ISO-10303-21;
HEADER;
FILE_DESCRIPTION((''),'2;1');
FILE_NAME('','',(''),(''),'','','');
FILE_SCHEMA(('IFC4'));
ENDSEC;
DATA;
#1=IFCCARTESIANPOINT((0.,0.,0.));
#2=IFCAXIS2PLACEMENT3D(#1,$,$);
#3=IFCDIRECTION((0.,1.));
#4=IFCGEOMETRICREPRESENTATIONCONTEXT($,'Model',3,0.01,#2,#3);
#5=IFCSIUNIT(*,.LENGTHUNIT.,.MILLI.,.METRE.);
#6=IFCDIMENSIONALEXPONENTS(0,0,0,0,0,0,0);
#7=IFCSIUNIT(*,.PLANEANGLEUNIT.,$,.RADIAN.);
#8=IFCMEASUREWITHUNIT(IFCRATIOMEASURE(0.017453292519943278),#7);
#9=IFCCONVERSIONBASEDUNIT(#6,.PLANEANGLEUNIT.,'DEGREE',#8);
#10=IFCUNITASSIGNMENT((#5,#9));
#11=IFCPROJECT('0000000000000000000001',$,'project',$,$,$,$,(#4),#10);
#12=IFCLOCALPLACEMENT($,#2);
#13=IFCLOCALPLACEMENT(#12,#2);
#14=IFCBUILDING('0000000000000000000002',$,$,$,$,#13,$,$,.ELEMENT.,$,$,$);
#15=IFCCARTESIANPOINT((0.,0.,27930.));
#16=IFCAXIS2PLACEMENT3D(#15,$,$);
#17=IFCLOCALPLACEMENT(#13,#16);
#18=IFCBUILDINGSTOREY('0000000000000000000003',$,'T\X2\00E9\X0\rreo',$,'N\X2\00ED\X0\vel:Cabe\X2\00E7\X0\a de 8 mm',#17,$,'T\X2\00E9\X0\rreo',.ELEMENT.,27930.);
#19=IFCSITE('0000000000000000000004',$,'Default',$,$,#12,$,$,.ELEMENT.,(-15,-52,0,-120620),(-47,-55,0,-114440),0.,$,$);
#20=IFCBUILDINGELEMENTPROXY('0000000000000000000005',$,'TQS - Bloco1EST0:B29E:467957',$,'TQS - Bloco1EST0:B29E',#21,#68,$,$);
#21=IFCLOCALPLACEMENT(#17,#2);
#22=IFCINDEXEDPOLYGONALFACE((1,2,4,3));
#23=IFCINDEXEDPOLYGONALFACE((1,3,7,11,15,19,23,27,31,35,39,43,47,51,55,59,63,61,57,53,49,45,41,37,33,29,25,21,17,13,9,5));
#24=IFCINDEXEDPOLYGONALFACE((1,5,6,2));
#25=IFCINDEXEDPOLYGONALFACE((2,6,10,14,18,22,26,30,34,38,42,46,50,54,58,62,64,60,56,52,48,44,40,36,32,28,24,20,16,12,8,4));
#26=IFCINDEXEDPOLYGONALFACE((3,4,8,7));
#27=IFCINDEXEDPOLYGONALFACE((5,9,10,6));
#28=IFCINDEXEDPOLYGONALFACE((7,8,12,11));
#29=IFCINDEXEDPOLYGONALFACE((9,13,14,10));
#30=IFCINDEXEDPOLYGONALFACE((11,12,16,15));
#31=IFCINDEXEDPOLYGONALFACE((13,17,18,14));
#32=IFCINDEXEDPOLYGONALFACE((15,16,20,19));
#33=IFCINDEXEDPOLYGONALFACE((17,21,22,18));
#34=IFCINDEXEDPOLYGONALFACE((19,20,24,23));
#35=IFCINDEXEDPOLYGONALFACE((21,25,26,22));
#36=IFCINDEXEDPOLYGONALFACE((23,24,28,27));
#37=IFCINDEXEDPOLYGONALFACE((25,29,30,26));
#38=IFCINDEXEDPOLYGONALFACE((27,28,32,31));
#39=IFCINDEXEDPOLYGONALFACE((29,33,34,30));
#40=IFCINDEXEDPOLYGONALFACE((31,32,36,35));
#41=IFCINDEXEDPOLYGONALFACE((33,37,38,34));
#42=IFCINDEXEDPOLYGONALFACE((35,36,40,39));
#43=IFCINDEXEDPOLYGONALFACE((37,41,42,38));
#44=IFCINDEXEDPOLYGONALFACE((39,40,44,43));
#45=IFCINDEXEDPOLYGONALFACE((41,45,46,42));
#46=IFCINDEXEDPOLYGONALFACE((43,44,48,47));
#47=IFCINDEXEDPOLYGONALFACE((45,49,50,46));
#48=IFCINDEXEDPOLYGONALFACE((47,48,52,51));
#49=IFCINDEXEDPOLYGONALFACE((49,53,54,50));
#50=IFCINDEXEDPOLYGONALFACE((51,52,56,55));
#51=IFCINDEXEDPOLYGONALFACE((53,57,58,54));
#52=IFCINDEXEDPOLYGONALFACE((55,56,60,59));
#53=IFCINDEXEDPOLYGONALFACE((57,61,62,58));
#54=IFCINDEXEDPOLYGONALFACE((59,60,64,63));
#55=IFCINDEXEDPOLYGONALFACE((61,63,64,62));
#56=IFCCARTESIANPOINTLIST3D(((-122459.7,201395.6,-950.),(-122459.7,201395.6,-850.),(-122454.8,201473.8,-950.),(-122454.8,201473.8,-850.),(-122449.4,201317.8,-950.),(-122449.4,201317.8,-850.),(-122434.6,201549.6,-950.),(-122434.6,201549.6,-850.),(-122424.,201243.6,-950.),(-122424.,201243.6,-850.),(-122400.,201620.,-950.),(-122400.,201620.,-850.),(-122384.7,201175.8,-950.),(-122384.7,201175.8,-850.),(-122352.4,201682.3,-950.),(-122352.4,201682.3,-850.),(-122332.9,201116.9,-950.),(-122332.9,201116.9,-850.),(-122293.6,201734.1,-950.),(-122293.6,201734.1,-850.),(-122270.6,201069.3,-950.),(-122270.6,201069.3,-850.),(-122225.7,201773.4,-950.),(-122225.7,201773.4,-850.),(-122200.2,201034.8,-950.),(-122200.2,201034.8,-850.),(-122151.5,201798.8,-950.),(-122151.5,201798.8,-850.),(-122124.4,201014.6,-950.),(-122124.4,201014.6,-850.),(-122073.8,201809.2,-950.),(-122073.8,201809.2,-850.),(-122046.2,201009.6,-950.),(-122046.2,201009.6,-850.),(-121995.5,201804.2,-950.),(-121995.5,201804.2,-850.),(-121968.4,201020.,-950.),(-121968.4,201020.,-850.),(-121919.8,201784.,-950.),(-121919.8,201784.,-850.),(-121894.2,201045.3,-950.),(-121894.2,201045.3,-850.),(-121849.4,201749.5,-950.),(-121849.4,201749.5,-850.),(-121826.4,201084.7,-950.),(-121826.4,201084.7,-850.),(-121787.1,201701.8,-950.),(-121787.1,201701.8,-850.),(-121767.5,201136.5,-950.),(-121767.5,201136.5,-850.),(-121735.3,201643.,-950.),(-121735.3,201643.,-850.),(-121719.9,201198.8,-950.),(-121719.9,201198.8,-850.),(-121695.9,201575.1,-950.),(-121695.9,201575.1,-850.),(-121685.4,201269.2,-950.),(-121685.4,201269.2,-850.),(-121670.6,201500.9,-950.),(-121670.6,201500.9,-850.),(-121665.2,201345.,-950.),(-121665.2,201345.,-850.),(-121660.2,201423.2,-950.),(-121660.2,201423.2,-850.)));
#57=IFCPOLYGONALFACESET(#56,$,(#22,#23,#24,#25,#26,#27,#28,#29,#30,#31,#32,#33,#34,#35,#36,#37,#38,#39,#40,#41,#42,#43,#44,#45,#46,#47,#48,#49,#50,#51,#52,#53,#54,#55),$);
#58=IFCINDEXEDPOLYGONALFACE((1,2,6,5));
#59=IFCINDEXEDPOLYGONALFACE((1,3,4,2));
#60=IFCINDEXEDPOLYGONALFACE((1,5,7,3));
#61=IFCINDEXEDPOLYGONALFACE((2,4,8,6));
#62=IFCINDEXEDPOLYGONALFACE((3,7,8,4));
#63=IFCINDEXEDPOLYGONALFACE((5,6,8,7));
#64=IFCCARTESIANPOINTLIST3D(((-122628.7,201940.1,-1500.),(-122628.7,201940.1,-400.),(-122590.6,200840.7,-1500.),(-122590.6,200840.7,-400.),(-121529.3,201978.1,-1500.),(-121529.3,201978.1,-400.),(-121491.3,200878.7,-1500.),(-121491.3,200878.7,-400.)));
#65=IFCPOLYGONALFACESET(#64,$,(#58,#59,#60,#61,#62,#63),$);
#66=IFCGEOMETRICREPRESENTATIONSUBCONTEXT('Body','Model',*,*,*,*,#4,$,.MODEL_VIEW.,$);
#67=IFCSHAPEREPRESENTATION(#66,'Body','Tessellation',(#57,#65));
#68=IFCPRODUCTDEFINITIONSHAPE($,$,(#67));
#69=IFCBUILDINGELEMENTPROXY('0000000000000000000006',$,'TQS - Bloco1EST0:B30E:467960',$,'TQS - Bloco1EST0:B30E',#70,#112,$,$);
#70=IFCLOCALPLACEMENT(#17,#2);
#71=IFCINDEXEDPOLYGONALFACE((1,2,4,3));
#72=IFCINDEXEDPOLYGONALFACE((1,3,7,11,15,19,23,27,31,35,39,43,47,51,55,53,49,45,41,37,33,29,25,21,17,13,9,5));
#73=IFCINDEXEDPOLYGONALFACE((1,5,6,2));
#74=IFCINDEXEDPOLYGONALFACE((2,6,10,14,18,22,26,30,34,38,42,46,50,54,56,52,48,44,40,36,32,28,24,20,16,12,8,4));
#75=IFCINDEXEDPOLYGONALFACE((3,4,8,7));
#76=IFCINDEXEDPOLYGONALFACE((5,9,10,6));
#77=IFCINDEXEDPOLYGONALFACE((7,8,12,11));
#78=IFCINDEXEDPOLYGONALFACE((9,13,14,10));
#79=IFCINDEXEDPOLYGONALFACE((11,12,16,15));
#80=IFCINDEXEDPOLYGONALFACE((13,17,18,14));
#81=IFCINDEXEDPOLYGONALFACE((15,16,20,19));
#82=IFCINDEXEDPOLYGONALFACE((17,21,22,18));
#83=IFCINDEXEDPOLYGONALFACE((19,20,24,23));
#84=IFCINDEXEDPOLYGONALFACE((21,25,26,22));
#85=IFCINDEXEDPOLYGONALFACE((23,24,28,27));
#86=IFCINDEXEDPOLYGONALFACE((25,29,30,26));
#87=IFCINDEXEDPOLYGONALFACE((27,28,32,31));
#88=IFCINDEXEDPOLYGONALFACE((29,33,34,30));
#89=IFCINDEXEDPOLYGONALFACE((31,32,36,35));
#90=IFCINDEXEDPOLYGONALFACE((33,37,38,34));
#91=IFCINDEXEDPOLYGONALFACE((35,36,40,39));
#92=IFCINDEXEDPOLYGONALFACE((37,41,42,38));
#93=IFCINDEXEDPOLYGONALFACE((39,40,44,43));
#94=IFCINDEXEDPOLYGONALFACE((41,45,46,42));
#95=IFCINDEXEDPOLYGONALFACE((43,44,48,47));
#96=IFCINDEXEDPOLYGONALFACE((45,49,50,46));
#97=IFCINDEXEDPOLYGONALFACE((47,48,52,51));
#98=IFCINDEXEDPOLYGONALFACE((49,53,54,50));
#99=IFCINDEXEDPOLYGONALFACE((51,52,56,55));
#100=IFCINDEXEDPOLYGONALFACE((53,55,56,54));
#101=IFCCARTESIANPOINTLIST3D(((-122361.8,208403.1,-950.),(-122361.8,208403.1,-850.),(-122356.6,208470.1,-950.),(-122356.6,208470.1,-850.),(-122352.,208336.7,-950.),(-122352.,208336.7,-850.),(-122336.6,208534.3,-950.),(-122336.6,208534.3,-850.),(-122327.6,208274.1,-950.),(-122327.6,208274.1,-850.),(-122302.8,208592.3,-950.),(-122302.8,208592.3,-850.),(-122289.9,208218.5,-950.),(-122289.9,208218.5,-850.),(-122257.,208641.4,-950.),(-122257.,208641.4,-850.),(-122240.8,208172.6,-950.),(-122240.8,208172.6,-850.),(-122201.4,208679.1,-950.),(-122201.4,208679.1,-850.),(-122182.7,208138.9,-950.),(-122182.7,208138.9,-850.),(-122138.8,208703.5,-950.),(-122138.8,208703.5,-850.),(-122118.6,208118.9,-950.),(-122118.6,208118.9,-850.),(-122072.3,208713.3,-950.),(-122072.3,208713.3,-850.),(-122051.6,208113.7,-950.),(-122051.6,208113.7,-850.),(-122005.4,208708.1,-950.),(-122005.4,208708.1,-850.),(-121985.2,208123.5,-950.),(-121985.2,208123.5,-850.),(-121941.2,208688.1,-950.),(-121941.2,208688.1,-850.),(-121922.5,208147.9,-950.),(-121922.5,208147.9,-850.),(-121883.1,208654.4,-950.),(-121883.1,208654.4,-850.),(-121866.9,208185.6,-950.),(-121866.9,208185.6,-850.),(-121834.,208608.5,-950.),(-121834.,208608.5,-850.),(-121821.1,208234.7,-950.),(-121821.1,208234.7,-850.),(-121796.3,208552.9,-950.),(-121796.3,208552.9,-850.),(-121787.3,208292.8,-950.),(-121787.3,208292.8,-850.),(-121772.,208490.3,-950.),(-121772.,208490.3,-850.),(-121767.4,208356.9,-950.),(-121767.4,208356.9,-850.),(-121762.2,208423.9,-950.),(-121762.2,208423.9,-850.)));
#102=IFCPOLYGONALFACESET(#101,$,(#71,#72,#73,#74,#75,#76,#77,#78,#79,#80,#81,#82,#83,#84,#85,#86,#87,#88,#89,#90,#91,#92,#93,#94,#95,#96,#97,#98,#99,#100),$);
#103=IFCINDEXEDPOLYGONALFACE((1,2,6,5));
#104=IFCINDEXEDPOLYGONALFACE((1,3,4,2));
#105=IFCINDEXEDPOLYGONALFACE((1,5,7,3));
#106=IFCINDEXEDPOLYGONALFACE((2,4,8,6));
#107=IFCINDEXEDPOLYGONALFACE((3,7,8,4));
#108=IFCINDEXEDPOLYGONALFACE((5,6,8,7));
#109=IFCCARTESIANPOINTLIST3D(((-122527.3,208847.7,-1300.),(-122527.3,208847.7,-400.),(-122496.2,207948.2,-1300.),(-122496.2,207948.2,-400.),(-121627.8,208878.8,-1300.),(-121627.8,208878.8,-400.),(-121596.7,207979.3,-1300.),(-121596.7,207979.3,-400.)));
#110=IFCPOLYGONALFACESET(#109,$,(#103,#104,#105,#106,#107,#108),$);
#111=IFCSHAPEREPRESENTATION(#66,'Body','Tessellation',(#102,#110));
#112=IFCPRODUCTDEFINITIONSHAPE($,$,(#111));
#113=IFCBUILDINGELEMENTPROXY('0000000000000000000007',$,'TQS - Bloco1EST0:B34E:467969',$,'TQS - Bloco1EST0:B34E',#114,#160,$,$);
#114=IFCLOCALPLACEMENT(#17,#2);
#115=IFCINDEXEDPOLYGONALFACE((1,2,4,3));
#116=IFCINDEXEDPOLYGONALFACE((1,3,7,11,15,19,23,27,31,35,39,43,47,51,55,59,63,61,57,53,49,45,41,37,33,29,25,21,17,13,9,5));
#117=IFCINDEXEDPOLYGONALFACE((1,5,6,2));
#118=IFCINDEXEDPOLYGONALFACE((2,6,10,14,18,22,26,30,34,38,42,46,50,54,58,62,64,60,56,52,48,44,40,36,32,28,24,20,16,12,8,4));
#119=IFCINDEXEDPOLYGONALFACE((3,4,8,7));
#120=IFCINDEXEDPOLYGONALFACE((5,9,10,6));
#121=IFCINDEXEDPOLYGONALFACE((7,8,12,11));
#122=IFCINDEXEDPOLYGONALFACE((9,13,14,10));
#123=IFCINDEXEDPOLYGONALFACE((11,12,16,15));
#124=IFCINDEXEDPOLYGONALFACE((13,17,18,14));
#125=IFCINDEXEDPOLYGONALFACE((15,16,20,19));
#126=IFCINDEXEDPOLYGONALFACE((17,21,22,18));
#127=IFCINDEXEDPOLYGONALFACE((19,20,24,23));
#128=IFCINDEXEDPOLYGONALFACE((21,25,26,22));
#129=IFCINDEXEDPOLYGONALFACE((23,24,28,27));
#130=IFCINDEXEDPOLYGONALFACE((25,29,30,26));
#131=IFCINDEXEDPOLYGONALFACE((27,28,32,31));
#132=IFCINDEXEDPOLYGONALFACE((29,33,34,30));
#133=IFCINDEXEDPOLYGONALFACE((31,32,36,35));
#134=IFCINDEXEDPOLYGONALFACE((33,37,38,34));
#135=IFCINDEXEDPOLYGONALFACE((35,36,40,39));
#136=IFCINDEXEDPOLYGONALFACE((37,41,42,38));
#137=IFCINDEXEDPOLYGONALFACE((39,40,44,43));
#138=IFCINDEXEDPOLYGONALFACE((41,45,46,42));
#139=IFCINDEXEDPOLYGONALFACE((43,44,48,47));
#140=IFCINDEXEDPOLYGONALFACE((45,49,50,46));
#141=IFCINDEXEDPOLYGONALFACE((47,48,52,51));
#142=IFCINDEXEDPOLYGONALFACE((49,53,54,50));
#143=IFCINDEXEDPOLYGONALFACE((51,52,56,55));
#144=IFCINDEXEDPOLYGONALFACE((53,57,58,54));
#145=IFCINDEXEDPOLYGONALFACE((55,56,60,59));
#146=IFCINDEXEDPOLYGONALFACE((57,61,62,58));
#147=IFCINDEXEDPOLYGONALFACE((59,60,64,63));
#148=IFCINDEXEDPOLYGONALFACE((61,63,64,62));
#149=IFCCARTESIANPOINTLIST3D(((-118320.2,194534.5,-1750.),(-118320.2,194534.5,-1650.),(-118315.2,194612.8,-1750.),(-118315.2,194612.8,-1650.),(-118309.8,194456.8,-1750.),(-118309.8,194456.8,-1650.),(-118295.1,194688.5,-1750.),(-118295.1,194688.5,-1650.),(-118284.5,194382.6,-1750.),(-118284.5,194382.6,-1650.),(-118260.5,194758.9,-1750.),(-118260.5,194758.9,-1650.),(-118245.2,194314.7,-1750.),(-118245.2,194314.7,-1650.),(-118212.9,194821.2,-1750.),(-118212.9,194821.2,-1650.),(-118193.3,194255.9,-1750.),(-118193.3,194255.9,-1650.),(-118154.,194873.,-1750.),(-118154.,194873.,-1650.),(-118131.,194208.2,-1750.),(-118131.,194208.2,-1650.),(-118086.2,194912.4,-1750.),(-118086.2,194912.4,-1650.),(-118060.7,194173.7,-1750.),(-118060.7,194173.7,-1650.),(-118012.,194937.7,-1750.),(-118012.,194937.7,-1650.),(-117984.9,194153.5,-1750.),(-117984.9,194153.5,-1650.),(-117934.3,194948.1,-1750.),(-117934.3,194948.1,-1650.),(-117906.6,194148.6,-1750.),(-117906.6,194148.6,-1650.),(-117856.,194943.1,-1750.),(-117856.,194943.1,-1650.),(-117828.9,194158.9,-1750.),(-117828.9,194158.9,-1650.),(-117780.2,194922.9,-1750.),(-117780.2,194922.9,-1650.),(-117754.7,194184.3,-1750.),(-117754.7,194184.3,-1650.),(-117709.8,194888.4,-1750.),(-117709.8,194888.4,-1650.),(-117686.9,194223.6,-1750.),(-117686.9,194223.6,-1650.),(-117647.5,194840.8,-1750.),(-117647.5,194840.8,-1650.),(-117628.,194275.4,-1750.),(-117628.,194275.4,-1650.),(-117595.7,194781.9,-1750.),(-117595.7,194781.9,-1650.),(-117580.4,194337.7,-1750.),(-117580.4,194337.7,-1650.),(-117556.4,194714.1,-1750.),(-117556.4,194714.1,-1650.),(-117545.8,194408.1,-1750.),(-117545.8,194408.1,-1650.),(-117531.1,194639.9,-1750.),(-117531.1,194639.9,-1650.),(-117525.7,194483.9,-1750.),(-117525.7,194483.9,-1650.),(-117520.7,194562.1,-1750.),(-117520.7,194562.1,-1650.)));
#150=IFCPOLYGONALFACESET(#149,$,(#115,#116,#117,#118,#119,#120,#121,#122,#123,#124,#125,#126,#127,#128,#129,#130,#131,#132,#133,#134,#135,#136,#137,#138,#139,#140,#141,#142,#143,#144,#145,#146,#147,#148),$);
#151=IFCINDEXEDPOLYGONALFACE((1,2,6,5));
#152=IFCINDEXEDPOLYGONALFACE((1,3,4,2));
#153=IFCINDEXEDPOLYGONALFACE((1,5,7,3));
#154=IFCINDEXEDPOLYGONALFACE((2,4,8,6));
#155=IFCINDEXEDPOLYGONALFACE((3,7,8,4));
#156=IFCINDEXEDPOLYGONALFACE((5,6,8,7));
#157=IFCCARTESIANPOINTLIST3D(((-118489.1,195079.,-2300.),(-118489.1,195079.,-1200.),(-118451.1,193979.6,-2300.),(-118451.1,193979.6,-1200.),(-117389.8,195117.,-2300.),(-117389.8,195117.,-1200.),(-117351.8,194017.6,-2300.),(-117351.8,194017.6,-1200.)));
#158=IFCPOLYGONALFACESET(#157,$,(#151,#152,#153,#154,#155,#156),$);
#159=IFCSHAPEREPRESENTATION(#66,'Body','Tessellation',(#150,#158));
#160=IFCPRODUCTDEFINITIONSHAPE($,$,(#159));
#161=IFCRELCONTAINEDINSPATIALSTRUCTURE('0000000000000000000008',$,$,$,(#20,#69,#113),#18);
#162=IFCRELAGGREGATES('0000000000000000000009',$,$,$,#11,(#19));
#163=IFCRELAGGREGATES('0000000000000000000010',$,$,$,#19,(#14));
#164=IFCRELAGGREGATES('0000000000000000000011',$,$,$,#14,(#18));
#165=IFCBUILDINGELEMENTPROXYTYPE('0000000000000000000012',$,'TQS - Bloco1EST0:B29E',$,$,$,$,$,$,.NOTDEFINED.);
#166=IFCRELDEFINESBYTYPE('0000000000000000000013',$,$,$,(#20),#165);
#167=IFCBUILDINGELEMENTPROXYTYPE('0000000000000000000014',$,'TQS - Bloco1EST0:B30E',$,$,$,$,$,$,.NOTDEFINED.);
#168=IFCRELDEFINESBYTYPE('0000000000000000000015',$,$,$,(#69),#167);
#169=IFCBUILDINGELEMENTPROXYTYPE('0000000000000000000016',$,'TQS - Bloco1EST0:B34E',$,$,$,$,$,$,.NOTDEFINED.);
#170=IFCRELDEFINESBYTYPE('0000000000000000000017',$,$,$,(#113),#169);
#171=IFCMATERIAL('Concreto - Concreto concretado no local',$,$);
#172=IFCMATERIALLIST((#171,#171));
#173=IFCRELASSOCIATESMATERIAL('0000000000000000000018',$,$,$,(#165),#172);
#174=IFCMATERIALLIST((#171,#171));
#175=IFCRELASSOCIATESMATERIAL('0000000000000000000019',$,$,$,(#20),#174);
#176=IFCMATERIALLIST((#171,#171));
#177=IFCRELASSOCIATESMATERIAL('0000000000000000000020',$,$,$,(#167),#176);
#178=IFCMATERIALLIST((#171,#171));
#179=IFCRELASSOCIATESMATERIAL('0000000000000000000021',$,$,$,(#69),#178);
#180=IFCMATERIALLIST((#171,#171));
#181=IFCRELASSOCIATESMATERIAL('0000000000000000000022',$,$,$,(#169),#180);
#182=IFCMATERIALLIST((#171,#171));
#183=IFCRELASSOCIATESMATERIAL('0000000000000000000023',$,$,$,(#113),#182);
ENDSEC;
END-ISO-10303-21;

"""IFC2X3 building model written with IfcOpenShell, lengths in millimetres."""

from ifc_helpers import new_model, entity, si_unit, converted_unit, direction, frame, frame_2d, origin, origin_2d_with_axis, place, context, subcontext, project, spatial, rectangle, circle, extrude, source, transform, mapped, material, material_list, type_object, type_shapes, element, save


model = new_model("IFC2X3")

# Units and contexts
model_context = context("Model", 3, precision=0.01, world=origin(), true_north=direction((0.0, 1.0)))
body_context = subcontext(model_context, "Body", "Model", "MODEL_VIEW")
ifc_project = project(units=[si_unit("LENGTHUNIT", "METRE", prefix="MILLI"), converted_unit("PLANEANGLEUNIT", "DEGREE", entity("IfcRatioMeasure", 0.017453292519943278), si_unit("PLANEANGLEUNIT", "RADIAN"), dimensions=[0, 0, 0, 0, 0, 0, 0])], contexts=[model_context])

# Site, building, storey
site_placement = place(None, origin())
site = spatial("IfcSite", under=ifc_project, at=site_placement, Name="Default", CompositionType="ELEMENT", RefLatitude=(-15, -52, 0, -120620), RefLongitude=(-47, -55, 0, -114440), RefElevation=0.0)
building_placement = place(site_placement, origin())
building = spatial("IfcBuilding", under=site, at=building_placement, CompositionType="ELEMENT")
storey_placement = place(building_placement, frame((0.0, 0.0, 27930.0)))
storey = spatial("IfcBuildingStorey", under=building, at=storey_placement, Name="Térreo", ObjectType="Nível:Cabeça de 8 mm", LongName="Térreo", CompositionType="ELEMENT", Elevation=27930.0)

# Building element proxies
ifc_material_1 = material(Name="Concreto - Concreto concretado no local")
ifc_material_list_1 = material_list([ifc_material_1, ifc_material_1])
ifc_material_list_2 = material_list([ifc_material_1, ifc_material_1])
building_element_proxy_type_1 = type_object("IfcBuildingElementProxyType", Name="TQS - Bloco1EST0:B29E", PredefinedType="NOTDEFINED", material=ifc_material_list_2)
shared_shape_1 = source(origin(), body_context, "Body", "SweptSolid", [
    extrude(circle(Radius=400.0, at=frame_2d((0.0, 0.0), x_axis=(1.0, 0.0))), frame((0.0, 0.0, -550.0)), (0.0, 0.0, 1.0), 100.0),
    extrude(rectangle(XDim=1100.0, YDim=1100.0, at=origin_2d_with_axis()), frame((0.0, 0.0, -1100.0), z_axis=(0.0, 0.0, 1.0), x_axis=(-1.0, 0.0, 0.0)), (0.0, 0.0, 1.0), 1100.0),
])
type_shapes(building_element_proxy_type_1, [shared_shape_1])
proxy_1_placement = place(storey_placement, frame((-122060.0, 201409.4, -400.0), z_axis=(0.0, 0.0, 1.0), x_axis=(-0.034551, 0.999403, 0.0)))
element("IfcBuildingElementProxy", 1, at=proxy_1_placement, inside=storey, type_object=building_element_proxy_type_1, material=ifc_material_list_1, Name="TQS - Bloco1EST0:B29E:467957", ObjectType="TQS - Bloco1EST0:B29E", context=body_context, shape_type="MappedRepresentation", body=[
    mapped(shared_shape_1, transform((0.0, 0.0, 0.0), scale=1.0)),
])
ifc_material_list_3 = material_list([ifc_material_1, ifc_material_1])
ifc_material_list_4 = material_list([ifc_material_1, ifc_material_1])
building_element_proxy_type_2 = type_object("IfcBuildingElementProxyType", Name="TQS - Bloco1EST0:B30E", PredefinedType="NOTDEFINED", material=ifc_material_list_4)
shared_shape_2 = source(origin(), body_context, "Body", "SweptSolid", [
    extrude(circle(Radius=300.0, at=frame_2d((0.0, 0.0), x_axis=(1.0, 0.0))), frame((0.0, 0.0, -550.0)), (0.0, 0.0, 1.0), 100.0),
    extrude(rectangle(XDim=900.0, YDim=900.0, at=origin_2d_with_axis()), frame((0.0, 0.0, -900.0), z_axis=(0.0, 0.0, 1.0), x_axis=(-1.0, 0.0, 0.0)), (0.0, 0.0, 1.0), 900.0),
])
type_shapes(building_element_proxy_type_2, [shared_shape_2])
proxy_2_placement = place(storey_placement, frame((-122062.0, 208413.5, -400.0), z_axis=(0.0, 0.0, 1.0), x_axis=(-0.034551, 0.999403, 0.0)))
element("IfcBuildingElementProxy", 2, at=proxy_2_placement, inside=storey, type_object=building_element_proxy_type_2, material=ifc_material_list_3, Name="TQS - Bloco1EST0:B30E:467960", ObjectType="TQS - Bloco1EST0:B30E", context=body_context, shape_type="MappedRepresentation", body=[
    mapped(shared_shape_2, transform((0.0, 0.0, 0.0), scale=1.0)),
])
ifc_material_list_5 = material_list([ifc_material_1, ifc_material_1])
ifc_material_list_6 = material_list([ifc_material_1, ifc_material_1])
building_element_proxy_type_3 = type_object("IfcBuildingElementProxyType", Name="TQS - Bloco1EST0:B34E", PredefinedType="NOTDEFINED", material=ifc_material_list_6)
shared_shape_3 = source(origin(), body_context, "Body", "SweptSolid", [
    extrude(circle(Radius=400.0, at=frame_2d((0.0, 0.0), x_axis=(1.0, 0.0))), frame((0.0, 0.0, -550.0)), (0.0, 0.0, 1.0), 100.0),
    extrude(rectangle(XDim=1100.0, YDim=1100.0, at=origin_2d_with_axis()), frame((0.0, 0.0, -1100.0), z_axis=(0.0, 0.0, 1.0), x_axis=(-1.0, 0.0, 0.0)), (0.0, 0.0, 1.0), 1100.0),
])
type_shapes(building_element_proxy_type_3, [shared_shape_3])
proxy_3_placement = place(storey_placement, frame((-117920.4, 194548.3, -1200.0), z_axis=(0.0, 0.0, 1.0), x_axis=(-0.034551, 0.999403, 0.0)))
element("IfcBuildingElementProxy", 3, at=proxy_3_placement, inside=storey, type_object=building_element_proxy_type_3, material=ifc_material_list_5, Name="TQS - Bloco1EST0:B34E:467969", ObjectType="TQS - Bloco1EST0:B34E", context=body_context, shape_type="MappedRepresentation", body=[
    mapped(shared_shape_3, transform((0.0, 0.0, 0.0), scale=1.0)),
])

save(model, "model.ifc")
